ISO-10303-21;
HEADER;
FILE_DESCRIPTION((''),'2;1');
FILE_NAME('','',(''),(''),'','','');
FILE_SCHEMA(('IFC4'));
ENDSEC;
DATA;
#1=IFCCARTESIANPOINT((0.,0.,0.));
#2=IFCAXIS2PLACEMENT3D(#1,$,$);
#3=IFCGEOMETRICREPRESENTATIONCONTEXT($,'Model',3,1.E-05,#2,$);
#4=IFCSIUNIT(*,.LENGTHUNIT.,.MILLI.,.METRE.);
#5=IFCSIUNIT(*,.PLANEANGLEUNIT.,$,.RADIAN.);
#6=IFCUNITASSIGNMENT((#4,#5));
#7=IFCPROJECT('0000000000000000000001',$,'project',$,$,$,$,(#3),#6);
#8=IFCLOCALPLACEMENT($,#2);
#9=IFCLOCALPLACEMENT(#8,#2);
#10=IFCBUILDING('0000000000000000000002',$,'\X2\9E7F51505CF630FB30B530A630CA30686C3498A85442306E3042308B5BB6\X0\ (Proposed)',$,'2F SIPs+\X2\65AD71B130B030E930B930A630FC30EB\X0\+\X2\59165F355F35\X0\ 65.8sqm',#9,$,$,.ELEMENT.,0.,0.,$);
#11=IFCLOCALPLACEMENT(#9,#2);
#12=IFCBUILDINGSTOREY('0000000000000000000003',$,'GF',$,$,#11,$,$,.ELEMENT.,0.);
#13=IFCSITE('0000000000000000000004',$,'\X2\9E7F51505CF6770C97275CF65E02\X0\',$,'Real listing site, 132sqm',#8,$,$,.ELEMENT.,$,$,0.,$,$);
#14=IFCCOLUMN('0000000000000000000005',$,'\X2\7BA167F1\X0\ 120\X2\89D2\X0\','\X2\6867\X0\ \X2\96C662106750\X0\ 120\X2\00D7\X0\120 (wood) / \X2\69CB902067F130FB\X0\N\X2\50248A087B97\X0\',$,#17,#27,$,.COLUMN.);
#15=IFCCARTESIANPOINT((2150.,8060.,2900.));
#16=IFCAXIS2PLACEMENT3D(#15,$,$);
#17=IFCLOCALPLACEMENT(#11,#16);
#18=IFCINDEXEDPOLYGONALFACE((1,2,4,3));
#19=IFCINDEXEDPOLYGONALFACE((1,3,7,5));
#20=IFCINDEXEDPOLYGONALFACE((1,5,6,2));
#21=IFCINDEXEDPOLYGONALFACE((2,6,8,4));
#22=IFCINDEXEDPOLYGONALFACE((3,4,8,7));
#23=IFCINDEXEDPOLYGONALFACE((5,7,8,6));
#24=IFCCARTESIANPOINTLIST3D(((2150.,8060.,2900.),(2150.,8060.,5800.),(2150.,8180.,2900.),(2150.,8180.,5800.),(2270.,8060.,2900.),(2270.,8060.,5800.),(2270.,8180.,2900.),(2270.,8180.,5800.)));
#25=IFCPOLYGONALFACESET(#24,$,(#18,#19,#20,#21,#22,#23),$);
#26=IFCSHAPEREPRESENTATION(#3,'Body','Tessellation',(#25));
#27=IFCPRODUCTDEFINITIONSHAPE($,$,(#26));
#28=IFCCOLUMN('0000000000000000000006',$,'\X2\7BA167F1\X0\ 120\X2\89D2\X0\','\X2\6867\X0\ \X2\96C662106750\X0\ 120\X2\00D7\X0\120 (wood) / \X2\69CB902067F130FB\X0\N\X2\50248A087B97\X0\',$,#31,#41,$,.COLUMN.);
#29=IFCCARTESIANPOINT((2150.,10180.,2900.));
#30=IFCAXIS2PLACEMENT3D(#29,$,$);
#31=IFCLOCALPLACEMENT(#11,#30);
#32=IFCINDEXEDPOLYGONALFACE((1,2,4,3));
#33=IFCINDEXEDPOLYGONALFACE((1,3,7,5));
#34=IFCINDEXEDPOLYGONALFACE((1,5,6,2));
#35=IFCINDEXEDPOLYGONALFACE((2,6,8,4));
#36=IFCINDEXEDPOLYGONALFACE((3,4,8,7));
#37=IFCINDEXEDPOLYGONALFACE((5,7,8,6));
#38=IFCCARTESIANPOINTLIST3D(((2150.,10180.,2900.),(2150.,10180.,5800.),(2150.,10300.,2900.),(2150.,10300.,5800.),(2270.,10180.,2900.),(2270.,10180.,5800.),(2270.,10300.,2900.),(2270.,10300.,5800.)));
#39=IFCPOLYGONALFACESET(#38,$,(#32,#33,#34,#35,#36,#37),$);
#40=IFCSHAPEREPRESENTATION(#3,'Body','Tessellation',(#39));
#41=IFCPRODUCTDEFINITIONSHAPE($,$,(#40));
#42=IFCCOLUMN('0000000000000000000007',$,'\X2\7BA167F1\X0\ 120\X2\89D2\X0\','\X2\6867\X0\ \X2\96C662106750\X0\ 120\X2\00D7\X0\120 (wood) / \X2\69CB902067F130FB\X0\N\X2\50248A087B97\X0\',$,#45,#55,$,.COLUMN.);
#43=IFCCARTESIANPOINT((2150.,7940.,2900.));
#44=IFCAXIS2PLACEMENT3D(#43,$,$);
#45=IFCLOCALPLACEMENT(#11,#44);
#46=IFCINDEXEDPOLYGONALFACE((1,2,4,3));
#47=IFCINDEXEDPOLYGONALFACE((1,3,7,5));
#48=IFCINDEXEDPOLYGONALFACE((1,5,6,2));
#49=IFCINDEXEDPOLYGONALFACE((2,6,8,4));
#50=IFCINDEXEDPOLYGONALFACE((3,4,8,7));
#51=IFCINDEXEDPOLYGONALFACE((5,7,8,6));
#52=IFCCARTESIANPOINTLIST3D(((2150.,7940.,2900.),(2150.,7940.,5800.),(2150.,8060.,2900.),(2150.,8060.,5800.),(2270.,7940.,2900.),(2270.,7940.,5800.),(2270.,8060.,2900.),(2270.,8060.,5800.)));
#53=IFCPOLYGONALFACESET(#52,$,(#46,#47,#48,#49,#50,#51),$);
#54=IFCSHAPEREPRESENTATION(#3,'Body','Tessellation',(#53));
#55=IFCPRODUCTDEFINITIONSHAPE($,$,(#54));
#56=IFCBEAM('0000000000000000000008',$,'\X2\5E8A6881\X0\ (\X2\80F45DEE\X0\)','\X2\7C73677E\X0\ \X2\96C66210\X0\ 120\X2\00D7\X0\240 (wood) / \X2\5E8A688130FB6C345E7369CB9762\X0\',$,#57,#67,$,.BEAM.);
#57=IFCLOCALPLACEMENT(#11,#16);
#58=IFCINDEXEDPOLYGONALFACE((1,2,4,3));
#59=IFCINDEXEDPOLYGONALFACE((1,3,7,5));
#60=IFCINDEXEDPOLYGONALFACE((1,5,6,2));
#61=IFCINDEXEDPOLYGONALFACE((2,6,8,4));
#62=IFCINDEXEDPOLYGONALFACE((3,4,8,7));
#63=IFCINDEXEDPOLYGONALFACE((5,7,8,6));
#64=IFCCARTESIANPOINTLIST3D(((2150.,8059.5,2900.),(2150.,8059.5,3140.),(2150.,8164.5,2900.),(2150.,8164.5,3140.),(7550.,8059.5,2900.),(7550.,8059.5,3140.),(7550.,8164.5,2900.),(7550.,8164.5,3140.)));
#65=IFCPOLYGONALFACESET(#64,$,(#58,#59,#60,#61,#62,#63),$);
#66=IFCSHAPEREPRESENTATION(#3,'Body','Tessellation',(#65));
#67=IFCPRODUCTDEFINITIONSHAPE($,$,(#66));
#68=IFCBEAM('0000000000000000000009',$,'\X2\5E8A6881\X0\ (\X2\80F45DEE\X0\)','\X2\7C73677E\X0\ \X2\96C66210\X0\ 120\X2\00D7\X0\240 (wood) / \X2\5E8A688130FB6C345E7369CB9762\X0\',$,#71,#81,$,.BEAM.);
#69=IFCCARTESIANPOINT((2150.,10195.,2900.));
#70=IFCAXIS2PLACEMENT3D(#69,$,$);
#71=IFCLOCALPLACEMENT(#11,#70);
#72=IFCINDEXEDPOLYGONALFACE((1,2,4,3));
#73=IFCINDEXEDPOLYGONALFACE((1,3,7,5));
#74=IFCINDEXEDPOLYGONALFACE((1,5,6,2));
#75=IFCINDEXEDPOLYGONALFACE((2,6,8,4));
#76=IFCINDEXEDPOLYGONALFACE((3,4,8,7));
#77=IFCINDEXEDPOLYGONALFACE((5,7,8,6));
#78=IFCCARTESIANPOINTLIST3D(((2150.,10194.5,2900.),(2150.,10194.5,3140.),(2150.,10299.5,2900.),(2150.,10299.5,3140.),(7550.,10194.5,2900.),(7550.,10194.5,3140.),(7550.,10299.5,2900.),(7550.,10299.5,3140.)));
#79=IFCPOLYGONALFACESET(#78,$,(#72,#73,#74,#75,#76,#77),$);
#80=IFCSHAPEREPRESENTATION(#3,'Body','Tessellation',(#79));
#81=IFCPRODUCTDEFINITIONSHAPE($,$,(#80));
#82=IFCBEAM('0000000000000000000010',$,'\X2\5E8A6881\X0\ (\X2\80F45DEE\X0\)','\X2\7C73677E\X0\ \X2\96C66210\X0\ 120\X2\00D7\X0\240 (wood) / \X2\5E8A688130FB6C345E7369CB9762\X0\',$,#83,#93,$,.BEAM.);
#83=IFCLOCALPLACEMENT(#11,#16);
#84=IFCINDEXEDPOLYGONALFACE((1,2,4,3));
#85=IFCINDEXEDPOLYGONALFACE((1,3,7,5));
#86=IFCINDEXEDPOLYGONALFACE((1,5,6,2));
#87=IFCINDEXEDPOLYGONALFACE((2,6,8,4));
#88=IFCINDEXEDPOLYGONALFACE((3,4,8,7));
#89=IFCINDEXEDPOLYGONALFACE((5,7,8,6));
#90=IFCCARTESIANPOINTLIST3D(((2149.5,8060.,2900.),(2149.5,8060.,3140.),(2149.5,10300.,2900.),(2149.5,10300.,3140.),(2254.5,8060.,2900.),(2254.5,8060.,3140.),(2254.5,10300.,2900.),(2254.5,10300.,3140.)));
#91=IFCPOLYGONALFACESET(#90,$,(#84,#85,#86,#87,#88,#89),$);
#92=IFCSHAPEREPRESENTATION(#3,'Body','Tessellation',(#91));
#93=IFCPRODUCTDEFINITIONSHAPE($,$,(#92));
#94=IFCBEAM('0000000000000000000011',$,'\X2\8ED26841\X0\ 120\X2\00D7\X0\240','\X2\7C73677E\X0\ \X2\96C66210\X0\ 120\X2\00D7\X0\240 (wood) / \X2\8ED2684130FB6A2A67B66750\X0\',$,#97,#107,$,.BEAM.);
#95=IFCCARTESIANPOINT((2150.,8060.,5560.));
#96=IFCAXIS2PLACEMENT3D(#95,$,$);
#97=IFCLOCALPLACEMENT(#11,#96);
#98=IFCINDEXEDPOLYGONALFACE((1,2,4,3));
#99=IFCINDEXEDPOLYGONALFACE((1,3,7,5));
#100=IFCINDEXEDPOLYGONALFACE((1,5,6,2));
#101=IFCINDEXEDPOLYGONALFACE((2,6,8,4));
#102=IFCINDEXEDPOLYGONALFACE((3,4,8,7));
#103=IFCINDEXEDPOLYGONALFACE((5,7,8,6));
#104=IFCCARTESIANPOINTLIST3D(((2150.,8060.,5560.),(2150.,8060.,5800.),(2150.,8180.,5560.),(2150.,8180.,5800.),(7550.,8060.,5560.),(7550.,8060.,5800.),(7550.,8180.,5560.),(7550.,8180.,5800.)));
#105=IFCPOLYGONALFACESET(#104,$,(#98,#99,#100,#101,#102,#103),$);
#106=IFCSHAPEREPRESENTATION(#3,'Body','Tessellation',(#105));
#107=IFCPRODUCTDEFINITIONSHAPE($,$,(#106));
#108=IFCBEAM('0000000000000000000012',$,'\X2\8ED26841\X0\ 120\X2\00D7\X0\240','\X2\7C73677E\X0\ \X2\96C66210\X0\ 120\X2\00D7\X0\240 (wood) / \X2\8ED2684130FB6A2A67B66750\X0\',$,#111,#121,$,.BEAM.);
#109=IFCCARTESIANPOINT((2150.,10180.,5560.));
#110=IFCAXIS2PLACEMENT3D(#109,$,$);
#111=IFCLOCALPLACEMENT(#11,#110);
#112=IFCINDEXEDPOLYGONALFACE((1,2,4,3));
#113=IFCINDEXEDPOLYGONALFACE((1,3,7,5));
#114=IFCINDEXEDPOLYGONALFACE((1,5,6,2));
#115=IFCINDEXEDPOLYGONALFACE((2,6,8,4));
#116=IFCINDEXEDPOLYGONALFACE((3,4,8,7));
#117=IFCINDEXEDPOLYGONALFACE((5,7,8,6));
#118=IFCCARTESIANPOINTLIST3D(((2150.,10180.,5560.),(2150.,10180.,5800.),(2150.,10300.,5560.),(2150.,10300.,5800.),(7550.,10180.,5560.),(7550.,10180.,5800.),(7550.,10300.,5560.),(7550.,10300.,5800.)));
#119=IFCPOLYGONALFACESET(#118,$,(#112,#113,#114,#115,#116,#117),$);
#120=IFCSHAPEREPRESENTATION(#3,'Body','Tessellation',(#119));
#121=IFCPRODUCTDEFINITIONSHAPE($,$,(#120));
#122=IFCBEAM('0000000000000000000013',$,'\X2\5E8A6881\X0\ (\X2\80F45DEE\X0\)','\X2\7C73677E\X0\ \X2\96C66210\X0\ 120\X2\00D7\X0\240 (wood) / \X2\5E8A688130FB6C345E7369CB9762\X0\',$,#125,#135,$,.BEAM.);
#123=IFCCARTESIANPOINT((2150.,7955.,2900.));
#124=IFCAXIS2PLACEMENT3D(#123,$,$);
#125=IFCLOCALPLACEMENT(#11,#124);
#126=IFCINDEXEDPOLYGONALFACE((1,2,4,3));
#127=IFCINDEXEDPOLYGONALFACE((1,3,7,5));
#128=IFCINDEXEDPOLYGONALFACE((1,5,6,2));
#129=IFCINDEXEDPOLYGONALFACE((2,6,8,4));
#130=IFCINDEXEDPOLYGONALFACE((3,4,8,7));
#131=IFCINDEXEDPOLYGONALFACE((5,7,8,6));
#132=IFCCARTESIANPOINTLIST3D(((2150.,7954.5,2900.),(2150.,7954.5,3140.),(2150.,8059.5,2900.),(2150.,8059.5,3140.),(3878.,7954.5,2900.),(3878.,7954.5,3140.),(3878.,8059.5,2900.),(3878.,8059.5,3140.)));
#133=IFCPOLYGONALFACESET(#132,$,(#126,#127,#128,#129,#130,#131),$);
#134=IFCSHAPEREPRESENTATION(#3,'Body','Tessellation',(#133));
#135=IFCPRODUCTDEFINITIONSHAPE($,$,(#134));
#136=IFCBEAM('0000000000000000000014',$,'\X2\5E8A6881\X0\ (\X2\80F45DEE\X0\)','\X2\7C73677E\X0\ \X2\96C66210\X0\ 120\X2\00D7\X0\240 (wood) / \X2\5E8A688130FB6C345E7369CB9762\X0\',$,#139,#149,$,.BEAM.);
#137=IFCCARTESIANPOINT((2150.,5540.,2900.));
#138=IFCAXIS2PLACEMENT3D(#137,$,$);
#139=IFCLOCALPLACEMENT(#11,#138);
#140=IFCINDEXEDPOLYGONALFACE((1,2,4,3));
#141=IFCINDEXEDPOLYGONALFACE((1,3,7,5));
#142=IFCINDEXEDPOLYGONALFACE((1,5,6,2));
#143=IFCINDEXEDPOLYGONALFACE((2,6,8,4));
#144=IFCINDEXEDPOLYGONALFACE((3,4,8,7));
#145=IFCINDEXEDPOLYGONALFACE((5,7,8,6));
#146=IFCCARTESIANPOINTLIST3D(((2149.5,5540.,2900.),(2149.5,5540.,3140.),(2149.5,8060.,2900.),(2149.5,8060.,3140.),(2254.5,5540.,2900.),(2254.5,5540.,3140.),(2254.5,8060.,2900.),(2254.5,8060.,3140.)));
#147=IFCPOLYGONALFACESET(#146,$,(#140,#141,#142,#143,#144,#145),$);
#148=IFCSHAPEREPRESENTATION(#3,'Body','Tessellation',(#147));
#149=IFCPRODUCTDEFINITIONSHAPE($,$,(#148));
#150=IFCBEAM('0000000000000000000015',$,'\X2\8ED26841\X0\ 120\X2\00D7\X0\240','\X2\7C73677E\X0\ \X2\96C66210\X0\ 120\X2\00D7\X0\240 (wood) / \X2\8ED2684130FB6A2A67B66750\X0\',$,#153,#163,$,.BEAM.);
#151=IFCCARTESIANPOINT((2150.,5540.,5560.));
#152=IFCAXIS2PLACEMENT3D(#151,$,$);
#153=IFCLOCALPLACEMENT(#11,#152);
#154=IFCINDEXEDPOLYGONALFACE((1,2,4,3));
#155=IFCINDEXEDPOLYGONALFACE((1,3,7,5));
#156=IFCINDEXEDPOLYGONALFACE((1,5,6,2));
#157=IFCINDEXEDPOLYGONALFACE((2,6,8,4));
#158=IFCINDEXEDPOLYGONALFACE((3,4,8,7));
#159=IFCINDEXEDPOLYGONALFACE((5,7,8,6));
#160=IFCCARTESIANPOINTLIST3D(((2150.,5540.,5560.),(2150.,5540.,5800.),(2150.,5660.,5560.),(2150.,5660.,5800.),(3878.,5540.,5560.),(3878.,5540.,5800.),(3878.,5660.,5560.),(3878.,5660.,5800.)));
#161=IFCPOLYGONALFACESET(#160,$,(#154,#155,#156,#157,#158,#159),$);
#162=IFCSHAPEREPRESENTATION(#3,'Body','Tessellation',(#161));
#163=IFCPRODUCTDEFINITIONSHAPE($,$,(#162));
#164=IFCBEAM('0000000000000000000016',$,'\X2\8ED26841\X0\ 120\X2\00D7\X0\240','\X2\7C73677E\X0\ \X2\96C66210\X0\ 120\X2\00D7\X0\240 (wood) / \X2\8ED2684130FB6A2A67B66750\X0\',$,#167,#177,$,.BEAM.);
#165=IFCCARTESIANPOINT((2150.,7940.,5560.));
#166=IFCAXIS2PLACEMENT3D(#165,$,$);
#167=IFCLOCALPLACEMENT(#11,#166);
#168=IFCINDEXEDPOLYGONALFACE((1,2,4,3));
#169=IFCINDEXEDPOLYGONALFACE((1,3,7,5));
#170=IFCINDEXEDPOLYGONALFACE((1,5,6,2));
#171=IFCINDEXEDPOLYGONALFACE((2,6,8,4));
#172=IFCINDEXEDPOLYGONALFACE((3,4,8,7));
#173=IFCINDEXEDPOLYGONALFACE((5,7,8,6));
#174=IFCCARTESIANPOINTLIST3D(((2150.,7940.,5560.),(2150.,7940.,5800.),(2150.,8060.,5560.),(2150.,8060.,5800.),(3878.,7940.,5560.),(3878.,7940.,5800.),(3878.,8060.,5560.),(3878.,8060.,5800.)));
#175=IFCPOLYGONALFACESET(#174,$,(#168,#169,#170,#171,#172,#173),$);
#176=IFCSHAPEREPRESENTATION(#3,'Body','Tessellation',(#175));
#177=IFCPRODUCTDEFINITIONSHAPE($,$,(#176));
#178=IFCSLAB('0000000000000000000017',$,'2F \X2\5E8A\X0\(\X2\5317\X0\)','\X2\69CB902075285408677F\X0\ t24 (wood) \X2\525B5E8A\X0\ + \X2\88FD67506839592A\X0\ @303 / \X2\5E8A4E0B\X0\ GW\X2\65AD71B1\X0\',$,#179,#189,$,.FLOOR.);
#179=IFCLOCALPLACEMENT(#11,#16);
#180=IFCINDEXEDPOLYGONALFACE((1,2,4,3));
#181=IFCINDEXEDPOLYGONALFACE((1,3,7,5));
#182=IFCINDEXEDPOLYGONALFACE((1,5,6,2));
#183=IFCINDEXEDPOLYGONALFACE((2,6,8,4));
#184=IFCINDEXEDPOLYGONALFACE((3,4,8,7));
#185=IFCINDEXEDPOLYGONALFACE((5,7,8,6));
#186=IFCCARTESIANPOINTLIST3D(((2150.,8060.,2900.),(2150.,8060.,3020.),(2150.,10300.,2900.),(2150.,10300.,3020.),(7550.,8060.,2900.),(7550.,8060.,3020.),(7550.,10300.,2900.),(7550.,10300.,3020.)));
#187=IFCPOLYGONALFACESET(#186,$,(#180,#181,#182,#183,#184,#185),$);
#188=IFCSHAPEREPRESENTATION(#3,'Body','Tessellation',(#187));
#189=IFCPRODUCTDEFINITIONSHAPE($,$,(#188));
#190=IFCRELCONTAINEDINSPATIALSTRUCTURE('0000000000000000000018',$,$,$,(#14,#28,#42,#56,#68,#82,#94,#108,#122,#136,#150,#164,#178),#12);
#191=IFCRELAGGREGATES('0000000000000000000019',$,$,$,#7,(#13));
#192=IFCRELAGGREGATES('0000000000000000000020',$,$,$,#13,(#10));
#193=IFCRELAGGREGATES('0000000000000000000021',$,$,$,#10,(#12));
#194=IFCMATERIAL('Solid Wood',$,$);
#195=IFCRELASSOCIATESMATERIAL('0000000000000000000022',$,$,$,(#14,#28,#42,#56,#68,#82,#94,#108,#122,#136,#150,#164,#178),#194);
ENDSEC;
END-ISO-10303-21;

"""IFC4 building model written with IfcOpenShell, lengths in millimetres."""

from ifc_helpers import new_model, si_unit, frame, frame_2d, origin, place, context, project, spatial, rectangle, extrude, material, element, save


model = new_model("IFC4")

# Units and contexts
model_context = context("Model", 3, precision=1e-05, world=origin())
ifc_project = project(units=[si_unit("LENGTHUNIT", "METRE", prefix="MILLI"), si_unit("PLANEANGLEUNIT", "RADIAN")], contexts=[model_context])

# Site, building, storey
site_placement = place(None, origin())
site = spatial("IfcSite", under=ifc_project, at=site_placement, Name="鹿児島県霧島市", ObjectType="Real listing site, 132sqm", CompositionType="ELEMENT", RefElevation=0.0)
building_placement = place(site_placement, origin())
building = spatial("IfcBuilding", under=site, at=building_placement, Name="鹿児島・サウナと水風呂のある家 (Proposed)", ObjectType="2F SIPs+断熱グラスウール+外張張 65.8sqm", CompositionType="ELEMENT", ElevationOfRefHeight=0.0, ElevationOfTerrain=0.0)
storey_placement = place(building_placement, origin())
storey = spatial("IfcBuildingStorey", under=building, at=storey_placement, Name="GF", CompositionType="ELEMENT", Elevation=0.0)

# Columns
ifc_material_1 = material(Name="Solid Wood")
column_1_placement = place(storey_placement, frame((2150.0, 8060.0, 2900.0)))
element("IfcColumn", 1, at=column_1_placement, inside=storey, material=ifc_material_1, Name="管柱 120角", Description="桧 集成材 120×120 (wood) / 構造柱・N値計算", PredefinedType="COLUMN", context=model_context, shape_type="SweptSolid", body=[
    extrude(rectangle(XDim=120.0, YDim=120.0, at=frame_2d((60.0, 60.0))), frame((2150.0, 8060.0, 2900.0)), (0.0, 0.0, 1.0), 2900.0),
])
column_2_placement = place(storey_placement, frame((2150.0, 10180.0, 2900.0)))
element("IfcColumn", 2, at=column_2_placement, inside=storey, material=ifc_material_1, Name="管柱 120角", Description="桧 集成材 120×120 (wood) / 構造柱・N値計算", PredefinedType="COLUMN", context=model_context, shape_type="SweptSolid", body=[
    extrude(rectangle(XDim=120.0, YDim=120.0, at=frame_2d((60.0, 60.0))), frame((2150.0, 10180.0, 2900.0)), (0.0, 0.0, 1.0), 2900.0),
])
column_3_placement = place(storey_placement, frame((2150.0, 7940.0, 2900.0)))
element("IfcColumn", 3, at=column_3_placement, inside=storey, material=ifc_material_1, Name="管柱 120角", Description="桧 集成材 120×120 (wood) / 構造柱・N値計算", PredefinedType="COLUMN", context=model_context, shape_type="SweptSolid", body=[
    extrude(rectangle(XDim=120.0, YDim=120.0, at=frame_2d((60.0, 60.0))), frame((2150.0, 7940.0, 2900.0)), (0.0, 0.0, 1.0), 2900.0),
])

# Beams
beam_1_placement = place(storey_placement, frame((2150.0, 8060.0, 2900.0)))
element("IfcBeam", 4, at=beam_1_placement, inside=storey, material=ifc_material_1, Name="床梁 (胴差)", Description="米松 集成 120×240 (wood) / 床梁・水平構面", PredefinedType="BEAM", context=model_context, shape_type="SweptSolid", body=[
    extrude(rectangle(XDim=5400.0, YDim=105.0, at=frame_2d((2700.0, 52.0))), frame((2150.0, 8060.0, 2900.0)), (0.0, 0.0, 1.0), 240.0),
])
beam_2_placement = place(storey_placement, frame((2150.0, 10195.0, 2900.0)))
element("IfcBeam", 5, at=beam_2_placement, inside=storey, material=ifc_material_1, Name="床梁 (胴差)", Description="米松 集成 120×240 (wood) / 床梁・水平構面", PredefinedType="BEAM", context=model_context, shape_type="SweptSolid", body=[
    extrude(rectangle(XDim=5400.0, YDim=105.0, at=frame_2d((2700.0, 52.0))), frame((2150.0, 10195.0, 2900.0)), (0.0, 0.0, 1.0), 240.0),
])
beam_3_placement = place(storey_placement, frame((2150.0, 8060.0, 2900.0)))
element("IfcBeam", 6, at=beam_3_placement, inside=storey, material=ifc_material_1, Name="床梁 (胴差)", Description="米松 集成 120×240 (wood) / 床梁・水平構面", PredefinedType="BEAM", context=model_context, shape_type="SweptSolid", body=[
    extrude(rectangle(XDim=105.0, YDim=2240.0, at=frame_2d((52.0, 1120.0))), frame((2150.0, 8060.0, 2900.0)), (0.0, 0.0, 1.0), 240.0),
])
beam_4_placement = place(storey_placement, frame((2150.0, 8060.0, 5560.0)))
element("IfcBeam", 7, at=beam_4_placement, inside=storey, material=ifc_material_1, Name="軒桁 120×240", Description="米松 集成 120×240 (wood) / 軒桁・横架材", PredefinedType="BEAM", context=model_context, shape_type="SweptSolid", body=[
    extrude(rectangle(XDim=5400.0, YDim=120.0, at=frame_2d((2700.0, 60.0))), frame((2150.0, 8060.0, 5560.0)), (0.0, 0.0, 1.0), 240.0),
])
beam_5_placement = place(storey_placement, frame((2150.0, 10180.0, 5560.0)))
element("IfcBeam", 8, at=beam_5_placement, inside=storey, material=ifc_material_1, Name="軒桁 120×240", Description="米松 集成 120×240 (wood) / 軒桁・横架材", PredefinedType="BEAM", context=model_context, shape_type="SweptSolid", body=[
    extrude(rectangle(XDim=5400.0, YDim=120.0, at=frame_2d((2700.0, 60.0))), frame((2150.0, 10180.0, 5560.0)), (0.0, 0.0, 1.0), 240.0),
])
beam_6_placement = place(storey_placement, frame((2150.0, 7955.0, 2900.0)))
element("IfcBeam", 9, at=beam_6_placement, inside=storey, material=ifc_material_1, Name="床梁 (胴差)", Description="米松 集成 120×240 (wood) / 床梁・水平構面", PredefinedType="BEAM", context=model_context, shape_type="SweptSolid", body=[
    extrude(rectangle(XDim=1728.0, YDim=105.0, at=frame_2d((864.0, 52.0))), frame((2150.0, 7955.0, 2900.0)), (0.0, 0.0, 1.0), 240.0),
])
beam_7_placement = place(storey_placement, frame((2150.0, 5540.0, 2900.0)))
element("IfcBeam", 10, at=beam_7_placement, inside=storey, material=ifc_material_1, Name="床梁 (胴差)", Description="米松 集成 120×240 (wood) / 床梁・水平構面", PredefinedType="BEAM", context=model_context, shape_type="SweptSolid", body=[
    extrude(rectangle(XDim=105.0, YDim=2520.0, at=frame_2d((52.0, 1260.0))), frame((2150.0, 5540.0, 2900.0)), (0.0, 0.0, 1.0), 240.0),
])
beam_8_placement = place(storey_placement, frame((2150.0, 5540.0, 5560.0)))
element("IfcBeam", 11, at=beam_8_placement, inside=storey, material=ifc_material_1, Name="軒桁 120×240", Description="米松 集成 120×240 (wood) / 軒桁・横架材", PredefinedType="BEAM", context=model_context, shape_type="SweptSolid", body=[
    extrude(rectangle(XDim=1728.0, YDim=120.0, at=frame_2d((864.0, 60.0))), frame((2150.0, 5540.0, 5560.0)), (0.0, 0.0, 1.0), 240.0),
])
beam_9_placement = place(storey_placement, frame((2150.0, 7940.0, 5560.0)))
element("IfcBeam", 12, at=beam_9_placement, inside=storey, material=ifc_material_1, Name="軒桁 120×240", Description="米松 集成 120×240 (wood) / 軒桁・横架材", PredefinedType="BEAM", context=model_context, shape_type="SweptSolid", body=[
    extrude(rectangle(XDim=1728.0, YDim=120.0, at=frame_2d((864.0, 60.0))), frame((2150.0, 7940.0, 5560.0)), (0.0, 0.0, 1.0), 240.0),
])

# Slab
slab_placement = place(storey_placement, frame((2150.0, 8060.0, 2900.0)))
element("IfcSlab", 13, at=slab_placement, inside=storey, material=ifc_material_1, Name="2F 床(北)", Description="構造用合板 t24 (wood) 剛床 + 製材根太 @303 / 床下 GW断熱", PredefinedType="FLOOR", context=model_context, shape_type="SweptSolid", body=[
    extrude(rectangle(XDim=5400.0, YDim=2240.0, at=frame_2d((2700.0, 1120.0))), frame((2150.0, 8060.0, 2900.0)), (0.0, 0.0, 1.0), 120.0),
])

save(model, "model.ifc")
